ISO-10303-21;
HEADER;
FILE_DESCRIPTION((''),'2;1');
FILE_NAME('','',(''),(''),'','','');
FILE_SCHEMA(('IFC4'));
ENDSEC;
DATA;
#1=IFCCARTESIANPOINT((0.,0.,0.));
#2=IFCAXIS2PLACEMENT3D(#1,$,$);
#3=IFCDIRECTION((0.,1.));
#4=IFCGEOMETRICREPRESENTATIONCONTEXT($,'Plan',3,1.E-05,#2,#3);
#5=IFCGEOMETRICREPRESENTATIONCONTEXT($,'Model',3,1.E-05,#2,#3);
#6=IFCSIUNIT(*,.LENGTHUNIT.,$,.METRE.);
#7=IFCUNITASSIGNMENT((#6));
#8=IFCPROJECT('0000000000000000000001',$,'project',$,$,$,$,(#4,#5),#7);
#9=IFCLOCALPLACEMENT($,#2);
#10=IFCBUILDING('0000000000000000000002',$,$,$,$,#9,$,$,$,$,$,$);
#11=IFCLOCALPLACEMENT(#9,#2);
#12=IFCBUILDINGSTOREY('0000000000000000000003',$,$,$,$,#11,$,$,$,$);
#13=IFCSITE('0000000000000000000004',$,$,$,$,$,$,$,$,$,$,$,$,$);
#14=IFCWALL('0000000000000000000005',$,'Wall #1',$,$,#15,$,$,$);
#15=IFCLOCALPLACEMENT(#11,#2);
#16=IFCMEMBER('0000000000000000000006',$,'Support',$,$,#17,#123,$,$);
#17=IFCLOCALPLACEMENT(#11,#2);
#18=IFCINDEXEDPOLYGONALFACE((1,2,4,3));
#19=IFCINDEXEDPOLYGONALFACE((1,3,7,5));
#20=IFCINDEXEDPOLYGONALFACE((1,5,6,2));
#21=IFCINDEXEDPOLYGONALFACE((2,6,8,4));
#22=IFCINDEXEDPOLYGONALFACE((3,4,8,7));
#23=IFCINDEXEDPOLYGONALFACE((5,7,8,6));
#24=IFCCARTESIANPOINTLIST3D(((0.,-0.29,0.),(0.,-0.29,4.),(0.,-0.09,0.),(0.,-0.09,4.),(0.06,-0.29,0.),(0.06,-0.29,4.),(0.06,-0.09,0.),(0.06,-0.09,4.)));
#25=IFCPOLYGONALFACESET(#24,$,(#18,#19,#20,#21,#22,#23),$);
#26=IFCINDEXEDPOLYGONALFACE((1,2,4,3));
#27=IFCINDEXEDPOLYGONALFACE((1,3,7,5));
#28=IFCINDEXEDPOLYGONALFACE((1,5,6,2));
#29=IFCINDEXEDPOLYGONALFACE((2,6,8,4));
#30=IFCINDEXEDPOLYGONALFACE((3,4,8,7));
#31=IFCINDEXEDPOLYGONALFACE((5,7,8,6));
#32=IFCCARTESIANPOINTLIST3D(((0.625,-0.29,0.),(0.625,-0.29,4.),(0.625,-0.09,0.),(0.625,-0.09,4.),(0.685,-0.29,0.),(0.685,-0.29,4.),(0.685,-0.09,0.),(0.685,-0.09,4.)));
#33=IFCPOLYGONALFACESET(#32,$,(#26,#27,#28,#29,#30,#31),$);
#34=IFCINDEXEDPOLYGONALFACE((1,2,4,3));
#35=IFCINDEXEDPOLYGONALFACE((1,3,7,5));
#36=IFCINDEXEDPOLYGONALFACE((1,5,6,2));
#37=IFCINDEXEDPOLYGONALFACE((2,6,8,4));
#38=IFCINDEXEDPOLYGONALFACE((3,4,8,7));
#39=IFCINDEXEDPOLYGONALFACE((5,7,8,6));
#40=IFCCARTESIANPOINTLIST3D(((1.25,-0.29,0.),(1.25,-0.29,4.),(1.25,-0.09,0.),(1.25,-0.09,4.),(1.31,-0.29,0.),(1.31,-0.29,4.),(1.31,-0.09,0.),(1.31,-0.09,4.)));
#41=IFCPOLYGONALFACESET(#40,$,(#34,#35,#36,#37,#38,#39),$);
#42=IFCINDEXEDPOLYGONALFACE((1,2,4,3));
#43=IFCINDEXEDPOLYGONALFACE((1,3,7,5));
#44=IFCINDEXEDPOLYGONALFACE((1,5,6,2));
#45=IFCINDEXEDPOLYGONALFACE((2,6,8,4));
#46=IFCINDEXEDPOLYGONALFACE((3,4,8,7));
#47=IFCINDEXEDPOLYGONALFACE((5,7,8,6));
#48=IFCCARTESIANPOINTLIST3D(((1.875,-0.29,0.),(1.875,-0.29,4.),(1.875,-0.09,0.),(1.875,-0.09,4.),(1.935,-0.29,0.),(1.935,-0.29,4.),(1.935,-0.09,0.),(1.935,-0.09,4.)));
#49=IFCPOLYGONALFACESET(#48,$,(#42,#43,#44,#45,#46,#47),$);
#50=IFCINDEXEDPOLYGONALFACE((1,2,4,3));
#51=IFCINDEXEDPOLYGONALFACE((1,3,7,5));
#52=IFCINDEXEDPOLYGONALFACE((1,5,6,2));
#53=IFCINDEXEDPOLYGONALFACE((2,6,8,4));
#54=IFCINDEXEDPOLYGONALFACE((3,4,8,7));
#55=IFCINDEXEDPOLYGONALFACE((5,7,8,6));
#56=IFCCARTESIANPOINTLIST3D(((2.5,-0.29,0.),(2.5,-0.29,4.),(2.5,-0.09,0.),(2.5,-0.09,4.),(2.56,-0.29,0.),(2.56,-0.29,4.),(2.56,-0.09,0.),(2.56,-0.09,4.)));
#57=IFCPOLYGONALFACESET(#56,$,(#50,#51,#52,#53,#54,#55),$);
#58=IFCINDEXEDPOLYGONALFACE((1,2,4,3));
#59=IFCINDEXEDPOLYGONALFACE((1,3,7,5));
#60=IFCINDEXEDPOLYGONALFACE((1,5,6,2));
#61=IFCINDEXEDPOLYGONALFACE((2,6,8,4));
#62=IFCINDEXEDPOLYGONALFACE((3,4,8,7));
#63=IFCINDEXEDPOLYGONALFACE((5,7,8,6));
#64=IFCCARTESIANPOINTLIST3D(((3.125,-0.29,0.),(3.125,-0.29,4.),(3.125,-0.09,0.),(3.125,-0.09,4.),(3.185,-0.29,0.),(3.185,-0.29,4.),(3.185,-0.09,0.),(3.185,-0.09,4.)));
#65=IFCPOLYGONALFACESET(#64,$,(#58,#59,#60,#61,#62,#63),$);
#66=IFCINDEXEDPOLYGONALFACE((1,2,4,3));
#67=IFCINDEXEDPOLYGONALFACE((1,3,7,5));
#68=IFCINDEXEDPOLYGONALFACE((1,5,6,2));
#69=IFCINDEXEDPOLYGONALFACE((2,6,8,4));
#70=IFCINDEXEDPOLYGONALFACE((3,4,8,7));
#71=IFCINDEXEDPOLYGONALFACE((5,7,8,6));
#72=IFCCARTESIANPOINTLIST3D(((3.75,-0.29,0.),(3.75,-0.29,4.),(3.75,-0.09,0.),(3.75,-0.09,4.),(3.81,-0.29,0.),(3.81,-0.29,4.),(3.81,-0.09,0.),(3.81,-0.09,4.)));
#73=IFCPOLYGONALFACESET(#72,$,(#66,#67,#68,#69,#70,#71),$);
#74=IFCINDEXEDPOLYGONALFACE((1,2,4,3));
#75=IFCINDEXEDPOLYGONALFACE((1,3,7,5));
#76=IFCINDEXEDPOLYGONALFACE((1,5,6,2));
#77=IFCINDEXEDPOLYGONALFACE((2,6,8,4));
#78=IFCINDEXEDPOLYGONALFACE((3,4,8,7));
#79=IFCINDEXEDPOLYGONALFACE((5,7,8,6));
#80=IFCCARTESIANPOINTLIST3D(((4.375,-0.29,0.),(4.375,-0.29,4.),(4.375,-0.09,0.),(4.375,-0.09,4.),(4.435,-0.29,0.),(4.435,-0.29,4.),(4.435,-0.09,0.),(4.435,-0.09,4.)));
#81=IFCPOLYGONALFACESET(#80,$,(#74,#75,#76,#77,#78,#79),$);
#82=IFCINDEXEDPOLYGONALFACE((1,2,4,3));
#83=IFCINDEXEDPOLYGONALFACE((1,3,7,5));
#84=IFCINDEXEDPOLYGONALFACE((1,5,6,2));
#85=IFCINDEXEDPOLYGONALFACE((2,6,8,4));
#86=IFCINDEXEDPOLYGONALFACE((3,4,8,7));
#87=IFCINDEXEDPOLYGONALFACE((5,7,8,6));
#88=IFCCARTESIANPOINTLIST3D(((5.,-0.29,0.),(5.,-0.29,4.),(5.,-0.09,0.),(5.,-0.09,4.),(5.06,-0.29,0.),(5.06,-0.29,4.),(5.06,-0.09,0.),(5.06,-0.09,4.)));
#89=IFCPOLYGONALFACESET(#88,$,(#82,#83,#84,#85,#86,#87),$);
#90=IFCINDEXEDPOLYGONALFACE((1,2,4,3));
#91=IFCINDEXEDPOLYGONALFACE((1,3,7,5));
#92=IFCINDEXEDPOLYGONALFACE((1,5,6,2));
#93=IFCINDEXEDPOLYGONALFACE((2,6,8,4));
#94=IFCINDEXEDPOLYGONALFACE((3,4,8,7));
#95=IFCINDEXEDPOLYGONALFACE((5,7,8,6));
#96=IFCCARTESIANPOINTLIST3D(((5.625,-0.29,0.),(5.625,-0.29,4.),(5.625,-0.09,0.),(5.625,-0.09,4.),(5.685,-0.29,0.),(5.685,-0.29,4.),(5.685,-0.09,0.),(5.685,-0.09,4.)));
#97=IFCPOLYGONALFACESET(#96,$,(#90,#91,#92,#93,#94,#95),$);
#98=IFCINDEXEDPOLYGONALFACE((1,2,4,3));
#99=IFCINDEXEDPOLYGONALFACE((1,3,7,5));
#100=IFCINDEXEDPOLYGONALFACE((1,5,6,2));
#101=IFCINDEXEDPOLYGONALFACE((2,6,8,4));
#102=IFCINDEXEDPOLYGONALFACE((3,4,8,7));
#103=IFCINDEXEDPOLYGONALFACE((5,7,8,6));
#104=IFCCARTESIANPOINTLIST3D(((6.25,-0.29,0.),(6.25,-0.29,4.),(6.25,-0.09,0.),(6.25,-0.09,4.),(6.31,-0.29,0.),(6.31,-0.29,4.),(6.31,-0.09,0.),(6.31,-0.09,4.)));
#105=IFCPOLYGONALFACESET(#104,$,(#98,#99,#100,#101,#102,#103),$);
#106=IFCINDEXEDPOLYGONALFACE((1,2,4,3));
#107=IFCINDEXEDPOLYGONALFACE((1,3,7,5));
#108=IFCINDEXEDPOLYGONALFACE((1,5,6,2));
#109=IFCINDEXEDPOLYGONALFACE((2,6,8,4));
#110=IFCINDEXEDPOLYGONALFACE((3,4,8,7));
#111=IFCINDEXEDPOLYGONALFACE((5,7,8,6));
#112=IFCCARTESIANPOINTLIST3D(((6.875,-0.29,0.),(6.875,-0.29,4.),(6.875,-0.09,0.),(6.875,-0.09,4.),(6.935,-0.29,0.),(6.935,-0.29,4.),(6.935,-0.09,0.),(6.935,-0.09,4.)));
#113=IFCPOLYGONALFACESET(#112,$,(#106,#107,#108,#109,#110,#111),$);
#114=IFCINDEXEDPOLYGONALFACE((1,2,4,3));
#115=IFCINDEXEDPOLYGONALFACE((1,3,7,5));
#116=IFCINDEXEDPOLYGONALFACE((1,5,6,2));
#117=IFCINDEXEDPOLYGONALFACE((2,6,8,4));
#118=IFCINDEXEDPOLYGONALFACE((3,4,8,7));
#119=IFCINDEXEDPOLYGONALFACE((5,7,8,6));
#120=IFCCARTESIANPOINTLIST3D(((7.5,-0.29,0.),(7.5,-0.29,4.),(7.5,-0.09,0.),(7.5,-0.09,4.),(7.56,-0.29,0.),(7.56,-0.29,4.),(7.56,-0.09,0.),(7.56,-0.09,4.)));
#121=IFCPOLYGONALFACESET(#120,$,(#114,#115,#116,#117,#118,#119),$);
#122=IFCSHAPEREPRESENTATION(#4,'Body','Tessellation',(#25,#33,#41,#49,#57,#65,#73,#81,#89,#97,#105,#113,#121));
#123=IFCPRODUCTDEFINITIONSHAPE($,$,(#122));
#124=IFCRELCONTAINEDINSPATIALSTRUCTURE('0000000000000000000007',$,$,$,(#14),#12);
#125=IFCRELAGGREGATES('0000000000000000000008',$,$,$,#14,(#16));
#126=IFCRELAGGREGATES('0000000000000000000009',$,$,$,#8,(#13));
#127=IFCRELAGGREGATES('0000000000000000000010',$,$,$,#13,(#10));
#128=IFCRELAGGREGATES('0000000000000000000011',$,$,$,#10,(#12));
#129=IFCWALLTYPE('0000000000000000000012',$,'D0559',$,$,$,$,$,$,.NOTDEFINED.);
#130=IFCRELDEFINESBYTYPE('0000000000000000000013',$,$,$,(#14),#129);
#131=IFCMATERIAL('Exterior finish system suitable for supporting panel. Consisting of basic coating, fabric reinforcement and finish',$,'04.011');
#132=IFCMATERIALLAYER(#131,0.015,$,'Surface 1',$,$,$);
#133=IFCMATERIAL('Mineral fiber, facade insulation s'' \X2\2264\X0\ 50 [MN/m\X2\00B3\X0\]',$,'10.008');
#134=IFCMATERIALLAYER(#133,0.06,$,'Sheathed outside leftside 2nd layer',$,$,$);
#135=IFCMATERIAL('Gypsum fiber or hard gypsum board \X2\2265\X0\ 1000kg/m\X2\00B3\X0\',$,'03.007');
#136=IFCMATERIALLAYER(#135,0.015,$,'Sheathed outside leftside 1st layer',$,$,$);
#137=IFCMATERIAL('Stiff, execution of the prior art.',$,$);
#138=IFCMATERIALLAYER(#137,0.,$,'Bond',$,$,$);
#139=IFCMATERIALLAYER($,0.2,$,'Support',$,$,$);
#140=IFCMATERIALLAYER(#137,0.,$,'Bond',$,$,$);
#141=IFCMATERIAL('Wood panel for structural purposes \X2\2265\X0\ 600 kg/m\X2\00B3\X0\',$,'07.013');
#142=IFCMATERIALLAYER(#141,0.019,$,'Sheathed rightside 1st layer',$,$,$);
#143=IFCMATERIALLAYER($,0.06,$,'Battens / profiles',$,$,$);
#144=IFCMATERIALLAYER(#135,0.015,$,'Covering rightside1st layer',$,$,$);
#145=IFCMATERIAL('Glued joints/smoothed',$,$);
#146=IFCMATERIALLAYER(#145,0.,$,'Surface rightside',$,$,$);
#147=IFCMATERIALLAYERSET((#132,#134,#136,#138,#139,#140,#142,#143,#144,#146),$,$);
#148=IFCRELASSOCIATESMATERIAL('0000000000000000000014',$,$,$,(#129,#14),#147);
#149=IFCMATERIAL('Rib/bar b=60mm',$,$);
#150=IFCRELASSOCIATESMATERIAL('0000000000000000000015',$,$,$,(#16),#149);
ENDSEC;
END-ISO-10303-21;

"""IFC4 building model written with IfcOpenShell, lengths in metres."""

from ifc_helpers import new_model, si_unit, direction, frame, frame_2d, origin, place, context, project, spatial, rectangle, extrude, material, layer, layer_set, type_object, element, aggregate, save


model = new_model("IFC4")

# Units and contexts
plan_context = context("Plan", 3, precision=1e-05, world=origin(), true_north=direction((0.0, 1.0)))
model_context = context("Model", 3, precision=1e-05, world=origin(), true_north=direction((0.0, 1.0)))
ifc_project = project(units=[si_unit("LENGTHUNIT", "METRE")], contexts=[plan_context, model_context])

# Site, building, storey
site = spatial("IfcSite", under=ifc_project)
building_placement = place(None, origin())
building = spatial("IfcBuilding", under=site, at=building_placement)
storey_placement = place(building_placement, origin())
storey = spatial("IfcBuildingStorey", under=building, at=storey_placement)

# Wall, member
ifc_material_1 = material(Name="Exterior finish system suitable for supporting panel. Consisting of basic coating, fabric reinforcement and finish", Category="04.011")
ifc_layer_1 = layer(ifc_material_1, 0.015, Name="Surface 1")
ifc_material_2 = material(Name="Mineral fiber, facade insulation s' ≤ 50 [MN/m³]", Category="10.008")
ifc_layer_2 = layer(ifc_material_2, 0.06, Name="Sheathed outside leftside 2nd layer")
ifc_material_3 = material(Name="Gypsum fiber or hard gypsum board ≥ 1000kg/m³", Category="03.007")
ifc_layer_3 = layer(ifc_material_3, 0.015, Name="Sheathed outside leftside 1st layer")
ifc_material_4 = material(Name="Stiff, execution of the prior art.")
ifc_layer_4 = layer(ifc_material_4, 0.0, Name="Bond")
ifc_layer_5 = layer(None, 0.2, Name="Support")
ifc_layer_6 = layer(ifc_material_4, 0.0, Name="Bond")
ifc_material_5 = material(Name="Wood panel for structural purposes ≥ 600 kg/m³", Category="07.013")
ifc_layer_7 = layer(ifc_material_5, 0.019, Name="Sheathed rightside 1st layer")
ifc_layer_8 = layer(None, 0.06, Name="Battens / profiles")
ifc_layer_9 = layer(ifc_material_3, 0.015, Name="Covering rightside1st layer")
ifc_material_6 = material(Name="Glued joints/smoothed")
ifc_layer_10 = layer(ifc_material_6, 0.0, Name="Surface rightside")
ifc_layer_set = layer_set([ifc_layer_1, ifc_layer_2, ifc_layer_3, ifc_layer_4, ifc_layer_5, ifc_layer_6, ifc_layer_7, ifc_layer_8, ifc_layer_9, ifc_layer_10])
wall_type = type_object("IfcWallType", Name="D0559", PredefinedType="NOTDEFINED", material=ifc_layer_set)
wall_placement = place(None, frame((0.0, 0.0, 0.0), z_axis=(0.0, -1.0, 0.0), x_axis=(1.0, 0.0, 0.0)))
wall = element("IfcWall", 1, at=wall_placement, inside=storey, type_object=wall_type, material=ifc_layer_set, Name="Wall #1")
ifc_material_7 = material(Name="Rib/bar b=60mm")
member_1_placement = place(wall_placement, origin())
member_1 = element("IfcMember", 2, at=member_1_placement, material=ifc_material_7, Name="Support", context=plan_context, shape_type="SweptSolid", body=[
    extrude(rectangle(XDim=0.06, YDim=0.2, at=frame_2d((0.03, 0.1), x_axis=(1.0, 0.0))), frame((0.0, 4.0, 0.09), z_axis=(0.0, -1.0, 0.0), x_axis=(1.0, 0.0, 0.0)), (0.0, 0.0, 1.0), 4.0),
    extrude(rectangle(XDim=0.06, YDim=0.2, at=frame_2d((0.03, 0.1), x_axis=(1.0, 0.0))), frame((0.625, 4.0, 0.09), z_axis=(0.0, -1.0, 0.0), x_axis=(1.0, 0.0, 0.0)), (0.0, 0.0, 1.0), 4.0),
    extrude(rectangle(XDim=0.06, YDim=0.2, at=frame_2d((0.03, 0.1), x_axis=(1.0, 0.0))), frame((1.25, 4.0, 0.09), z_axis=(0.0, -1.0, 0.0), x_axis=(1.0, 0.0, 0.0)), (0.0, 0.0, 1.0), 4.0),
    extrude(rectangle(XDim=0.06, YDim=0.2, at=frame_2d((0.03, 0.1), x_axis=(1.0, 0.0))), frame((1.875, 4.0, 0.09), z_axis=(0.0, -1.0, 0.0), x_axis=(1.0, 0.0, 0.0)), (0.0, 0.0, 1.0), 4.0),
    extrude(rectangle(XDim=0.06, YDim=0.2, at=frame_2d((0.03, 0.1), x_axis=(1.0, 0.0))), frame((2.5, 4.0, 0.09), z_axis=(0.0, -1.0, 0.0), x_axis=(1.0, 0.0, 0.0)), (0.0, 0.0, 1.0), 4.0),
    extrude(rectangle(XDim=0.06, YDim=0.2, at=frame_2d((0.03, 0.1), x_axis=(1.0, 0.0))), frame((3.125, 4.0, 0.09), z_axis=(0.0, -1.0, 0.0), x_axis=(1.0, 0.0, 0.0)), (0.0, 0.0, 1.0), 4.0),
    extrude(rectangle(XDim=0.06, YDim=0.2, at=frame_2d((0.03, 0.1), x_axis=(1.0, 0.0))), frame((3.75, 4.0, 0.09), z_axis=(0.0, -1.0, 0.0), x_axis=(1.0, 0.0, 0.0)), (0.0, 0.0, 1.0), 4.0),
    extrude(rectangle(XDim=0.06, YDim=0.2, at=frame_2d((0.03, 0.1), x_axis=(1.0, 0.0))), frame((4.375, 4.0, 0.09), z_axis=(0.0, -1.0, 0.0), x_axis=(1.0, 0.0, 0.0)), (0.0, 0.0, 1.0), 4.0),
    extrude(rectangle(XDim=0.06, YDim=0.2, at=frame_2d((0.03, 0.1), x_axis=(1.0, 0.0))), frame((5.0, 4.0, 0.09), z_axis=(0.0, -1.0, 0.0), x_axis=(1.0, 0.0, 0.0)), (0.0, 0.0, 1.0), 4.0),
    extrude(rectangle(XDim=0.06, YDim=0.2, at=frame_2d((0.03, 0.1), x_axis=(1.0, 0.0))), frame((5.625, 4.0, 0.09), z_axis=(0.0, -1.0, 0.0), x_axis=(1.0, 0.0, 0.0)), (0.0, 0.0, 1.0), 4.0),
    extrude(rectangle(XDim=0.06, YDim=0.2, at=frame_2d((0.03, 0.1), x_axis=(1.0, 0.0))), frame((6.25, 4.0, 0.09), z_axis=(0.0, -1.0, 0.0), x_axis=(1.0, 0.0, 0.0)), (0.0, 0.0, 1.0), 4.0),
    extrude(rectangle(XDim=0.06, YDim=0.2, at=frame_2d((0.03, 0.1), x_axis=(1.0, 0.0))), frame((6.875, 4.0, 0.09), z_axis=(0.0, -1.0, 0.0), x_axis=(1.0, 0.0, 0.0)), (0.0, 0.0, 1.0), 4.0),
    extrude(rectangle(XDim=0.06, YDim=0.2, at=frame_2d((0.03, 0.1), x_axis=(1.0, 0.0))), frame((7.5, 4.0, 0.09), z_axis=(0.0, -1.0, 0.0), x_axis=(1.0, 0.0, 0.0)), (0.0, 0.0, 1.0), 4.0),
])
aggregate(wall, [member_1])

save(model, "model.ifc")
